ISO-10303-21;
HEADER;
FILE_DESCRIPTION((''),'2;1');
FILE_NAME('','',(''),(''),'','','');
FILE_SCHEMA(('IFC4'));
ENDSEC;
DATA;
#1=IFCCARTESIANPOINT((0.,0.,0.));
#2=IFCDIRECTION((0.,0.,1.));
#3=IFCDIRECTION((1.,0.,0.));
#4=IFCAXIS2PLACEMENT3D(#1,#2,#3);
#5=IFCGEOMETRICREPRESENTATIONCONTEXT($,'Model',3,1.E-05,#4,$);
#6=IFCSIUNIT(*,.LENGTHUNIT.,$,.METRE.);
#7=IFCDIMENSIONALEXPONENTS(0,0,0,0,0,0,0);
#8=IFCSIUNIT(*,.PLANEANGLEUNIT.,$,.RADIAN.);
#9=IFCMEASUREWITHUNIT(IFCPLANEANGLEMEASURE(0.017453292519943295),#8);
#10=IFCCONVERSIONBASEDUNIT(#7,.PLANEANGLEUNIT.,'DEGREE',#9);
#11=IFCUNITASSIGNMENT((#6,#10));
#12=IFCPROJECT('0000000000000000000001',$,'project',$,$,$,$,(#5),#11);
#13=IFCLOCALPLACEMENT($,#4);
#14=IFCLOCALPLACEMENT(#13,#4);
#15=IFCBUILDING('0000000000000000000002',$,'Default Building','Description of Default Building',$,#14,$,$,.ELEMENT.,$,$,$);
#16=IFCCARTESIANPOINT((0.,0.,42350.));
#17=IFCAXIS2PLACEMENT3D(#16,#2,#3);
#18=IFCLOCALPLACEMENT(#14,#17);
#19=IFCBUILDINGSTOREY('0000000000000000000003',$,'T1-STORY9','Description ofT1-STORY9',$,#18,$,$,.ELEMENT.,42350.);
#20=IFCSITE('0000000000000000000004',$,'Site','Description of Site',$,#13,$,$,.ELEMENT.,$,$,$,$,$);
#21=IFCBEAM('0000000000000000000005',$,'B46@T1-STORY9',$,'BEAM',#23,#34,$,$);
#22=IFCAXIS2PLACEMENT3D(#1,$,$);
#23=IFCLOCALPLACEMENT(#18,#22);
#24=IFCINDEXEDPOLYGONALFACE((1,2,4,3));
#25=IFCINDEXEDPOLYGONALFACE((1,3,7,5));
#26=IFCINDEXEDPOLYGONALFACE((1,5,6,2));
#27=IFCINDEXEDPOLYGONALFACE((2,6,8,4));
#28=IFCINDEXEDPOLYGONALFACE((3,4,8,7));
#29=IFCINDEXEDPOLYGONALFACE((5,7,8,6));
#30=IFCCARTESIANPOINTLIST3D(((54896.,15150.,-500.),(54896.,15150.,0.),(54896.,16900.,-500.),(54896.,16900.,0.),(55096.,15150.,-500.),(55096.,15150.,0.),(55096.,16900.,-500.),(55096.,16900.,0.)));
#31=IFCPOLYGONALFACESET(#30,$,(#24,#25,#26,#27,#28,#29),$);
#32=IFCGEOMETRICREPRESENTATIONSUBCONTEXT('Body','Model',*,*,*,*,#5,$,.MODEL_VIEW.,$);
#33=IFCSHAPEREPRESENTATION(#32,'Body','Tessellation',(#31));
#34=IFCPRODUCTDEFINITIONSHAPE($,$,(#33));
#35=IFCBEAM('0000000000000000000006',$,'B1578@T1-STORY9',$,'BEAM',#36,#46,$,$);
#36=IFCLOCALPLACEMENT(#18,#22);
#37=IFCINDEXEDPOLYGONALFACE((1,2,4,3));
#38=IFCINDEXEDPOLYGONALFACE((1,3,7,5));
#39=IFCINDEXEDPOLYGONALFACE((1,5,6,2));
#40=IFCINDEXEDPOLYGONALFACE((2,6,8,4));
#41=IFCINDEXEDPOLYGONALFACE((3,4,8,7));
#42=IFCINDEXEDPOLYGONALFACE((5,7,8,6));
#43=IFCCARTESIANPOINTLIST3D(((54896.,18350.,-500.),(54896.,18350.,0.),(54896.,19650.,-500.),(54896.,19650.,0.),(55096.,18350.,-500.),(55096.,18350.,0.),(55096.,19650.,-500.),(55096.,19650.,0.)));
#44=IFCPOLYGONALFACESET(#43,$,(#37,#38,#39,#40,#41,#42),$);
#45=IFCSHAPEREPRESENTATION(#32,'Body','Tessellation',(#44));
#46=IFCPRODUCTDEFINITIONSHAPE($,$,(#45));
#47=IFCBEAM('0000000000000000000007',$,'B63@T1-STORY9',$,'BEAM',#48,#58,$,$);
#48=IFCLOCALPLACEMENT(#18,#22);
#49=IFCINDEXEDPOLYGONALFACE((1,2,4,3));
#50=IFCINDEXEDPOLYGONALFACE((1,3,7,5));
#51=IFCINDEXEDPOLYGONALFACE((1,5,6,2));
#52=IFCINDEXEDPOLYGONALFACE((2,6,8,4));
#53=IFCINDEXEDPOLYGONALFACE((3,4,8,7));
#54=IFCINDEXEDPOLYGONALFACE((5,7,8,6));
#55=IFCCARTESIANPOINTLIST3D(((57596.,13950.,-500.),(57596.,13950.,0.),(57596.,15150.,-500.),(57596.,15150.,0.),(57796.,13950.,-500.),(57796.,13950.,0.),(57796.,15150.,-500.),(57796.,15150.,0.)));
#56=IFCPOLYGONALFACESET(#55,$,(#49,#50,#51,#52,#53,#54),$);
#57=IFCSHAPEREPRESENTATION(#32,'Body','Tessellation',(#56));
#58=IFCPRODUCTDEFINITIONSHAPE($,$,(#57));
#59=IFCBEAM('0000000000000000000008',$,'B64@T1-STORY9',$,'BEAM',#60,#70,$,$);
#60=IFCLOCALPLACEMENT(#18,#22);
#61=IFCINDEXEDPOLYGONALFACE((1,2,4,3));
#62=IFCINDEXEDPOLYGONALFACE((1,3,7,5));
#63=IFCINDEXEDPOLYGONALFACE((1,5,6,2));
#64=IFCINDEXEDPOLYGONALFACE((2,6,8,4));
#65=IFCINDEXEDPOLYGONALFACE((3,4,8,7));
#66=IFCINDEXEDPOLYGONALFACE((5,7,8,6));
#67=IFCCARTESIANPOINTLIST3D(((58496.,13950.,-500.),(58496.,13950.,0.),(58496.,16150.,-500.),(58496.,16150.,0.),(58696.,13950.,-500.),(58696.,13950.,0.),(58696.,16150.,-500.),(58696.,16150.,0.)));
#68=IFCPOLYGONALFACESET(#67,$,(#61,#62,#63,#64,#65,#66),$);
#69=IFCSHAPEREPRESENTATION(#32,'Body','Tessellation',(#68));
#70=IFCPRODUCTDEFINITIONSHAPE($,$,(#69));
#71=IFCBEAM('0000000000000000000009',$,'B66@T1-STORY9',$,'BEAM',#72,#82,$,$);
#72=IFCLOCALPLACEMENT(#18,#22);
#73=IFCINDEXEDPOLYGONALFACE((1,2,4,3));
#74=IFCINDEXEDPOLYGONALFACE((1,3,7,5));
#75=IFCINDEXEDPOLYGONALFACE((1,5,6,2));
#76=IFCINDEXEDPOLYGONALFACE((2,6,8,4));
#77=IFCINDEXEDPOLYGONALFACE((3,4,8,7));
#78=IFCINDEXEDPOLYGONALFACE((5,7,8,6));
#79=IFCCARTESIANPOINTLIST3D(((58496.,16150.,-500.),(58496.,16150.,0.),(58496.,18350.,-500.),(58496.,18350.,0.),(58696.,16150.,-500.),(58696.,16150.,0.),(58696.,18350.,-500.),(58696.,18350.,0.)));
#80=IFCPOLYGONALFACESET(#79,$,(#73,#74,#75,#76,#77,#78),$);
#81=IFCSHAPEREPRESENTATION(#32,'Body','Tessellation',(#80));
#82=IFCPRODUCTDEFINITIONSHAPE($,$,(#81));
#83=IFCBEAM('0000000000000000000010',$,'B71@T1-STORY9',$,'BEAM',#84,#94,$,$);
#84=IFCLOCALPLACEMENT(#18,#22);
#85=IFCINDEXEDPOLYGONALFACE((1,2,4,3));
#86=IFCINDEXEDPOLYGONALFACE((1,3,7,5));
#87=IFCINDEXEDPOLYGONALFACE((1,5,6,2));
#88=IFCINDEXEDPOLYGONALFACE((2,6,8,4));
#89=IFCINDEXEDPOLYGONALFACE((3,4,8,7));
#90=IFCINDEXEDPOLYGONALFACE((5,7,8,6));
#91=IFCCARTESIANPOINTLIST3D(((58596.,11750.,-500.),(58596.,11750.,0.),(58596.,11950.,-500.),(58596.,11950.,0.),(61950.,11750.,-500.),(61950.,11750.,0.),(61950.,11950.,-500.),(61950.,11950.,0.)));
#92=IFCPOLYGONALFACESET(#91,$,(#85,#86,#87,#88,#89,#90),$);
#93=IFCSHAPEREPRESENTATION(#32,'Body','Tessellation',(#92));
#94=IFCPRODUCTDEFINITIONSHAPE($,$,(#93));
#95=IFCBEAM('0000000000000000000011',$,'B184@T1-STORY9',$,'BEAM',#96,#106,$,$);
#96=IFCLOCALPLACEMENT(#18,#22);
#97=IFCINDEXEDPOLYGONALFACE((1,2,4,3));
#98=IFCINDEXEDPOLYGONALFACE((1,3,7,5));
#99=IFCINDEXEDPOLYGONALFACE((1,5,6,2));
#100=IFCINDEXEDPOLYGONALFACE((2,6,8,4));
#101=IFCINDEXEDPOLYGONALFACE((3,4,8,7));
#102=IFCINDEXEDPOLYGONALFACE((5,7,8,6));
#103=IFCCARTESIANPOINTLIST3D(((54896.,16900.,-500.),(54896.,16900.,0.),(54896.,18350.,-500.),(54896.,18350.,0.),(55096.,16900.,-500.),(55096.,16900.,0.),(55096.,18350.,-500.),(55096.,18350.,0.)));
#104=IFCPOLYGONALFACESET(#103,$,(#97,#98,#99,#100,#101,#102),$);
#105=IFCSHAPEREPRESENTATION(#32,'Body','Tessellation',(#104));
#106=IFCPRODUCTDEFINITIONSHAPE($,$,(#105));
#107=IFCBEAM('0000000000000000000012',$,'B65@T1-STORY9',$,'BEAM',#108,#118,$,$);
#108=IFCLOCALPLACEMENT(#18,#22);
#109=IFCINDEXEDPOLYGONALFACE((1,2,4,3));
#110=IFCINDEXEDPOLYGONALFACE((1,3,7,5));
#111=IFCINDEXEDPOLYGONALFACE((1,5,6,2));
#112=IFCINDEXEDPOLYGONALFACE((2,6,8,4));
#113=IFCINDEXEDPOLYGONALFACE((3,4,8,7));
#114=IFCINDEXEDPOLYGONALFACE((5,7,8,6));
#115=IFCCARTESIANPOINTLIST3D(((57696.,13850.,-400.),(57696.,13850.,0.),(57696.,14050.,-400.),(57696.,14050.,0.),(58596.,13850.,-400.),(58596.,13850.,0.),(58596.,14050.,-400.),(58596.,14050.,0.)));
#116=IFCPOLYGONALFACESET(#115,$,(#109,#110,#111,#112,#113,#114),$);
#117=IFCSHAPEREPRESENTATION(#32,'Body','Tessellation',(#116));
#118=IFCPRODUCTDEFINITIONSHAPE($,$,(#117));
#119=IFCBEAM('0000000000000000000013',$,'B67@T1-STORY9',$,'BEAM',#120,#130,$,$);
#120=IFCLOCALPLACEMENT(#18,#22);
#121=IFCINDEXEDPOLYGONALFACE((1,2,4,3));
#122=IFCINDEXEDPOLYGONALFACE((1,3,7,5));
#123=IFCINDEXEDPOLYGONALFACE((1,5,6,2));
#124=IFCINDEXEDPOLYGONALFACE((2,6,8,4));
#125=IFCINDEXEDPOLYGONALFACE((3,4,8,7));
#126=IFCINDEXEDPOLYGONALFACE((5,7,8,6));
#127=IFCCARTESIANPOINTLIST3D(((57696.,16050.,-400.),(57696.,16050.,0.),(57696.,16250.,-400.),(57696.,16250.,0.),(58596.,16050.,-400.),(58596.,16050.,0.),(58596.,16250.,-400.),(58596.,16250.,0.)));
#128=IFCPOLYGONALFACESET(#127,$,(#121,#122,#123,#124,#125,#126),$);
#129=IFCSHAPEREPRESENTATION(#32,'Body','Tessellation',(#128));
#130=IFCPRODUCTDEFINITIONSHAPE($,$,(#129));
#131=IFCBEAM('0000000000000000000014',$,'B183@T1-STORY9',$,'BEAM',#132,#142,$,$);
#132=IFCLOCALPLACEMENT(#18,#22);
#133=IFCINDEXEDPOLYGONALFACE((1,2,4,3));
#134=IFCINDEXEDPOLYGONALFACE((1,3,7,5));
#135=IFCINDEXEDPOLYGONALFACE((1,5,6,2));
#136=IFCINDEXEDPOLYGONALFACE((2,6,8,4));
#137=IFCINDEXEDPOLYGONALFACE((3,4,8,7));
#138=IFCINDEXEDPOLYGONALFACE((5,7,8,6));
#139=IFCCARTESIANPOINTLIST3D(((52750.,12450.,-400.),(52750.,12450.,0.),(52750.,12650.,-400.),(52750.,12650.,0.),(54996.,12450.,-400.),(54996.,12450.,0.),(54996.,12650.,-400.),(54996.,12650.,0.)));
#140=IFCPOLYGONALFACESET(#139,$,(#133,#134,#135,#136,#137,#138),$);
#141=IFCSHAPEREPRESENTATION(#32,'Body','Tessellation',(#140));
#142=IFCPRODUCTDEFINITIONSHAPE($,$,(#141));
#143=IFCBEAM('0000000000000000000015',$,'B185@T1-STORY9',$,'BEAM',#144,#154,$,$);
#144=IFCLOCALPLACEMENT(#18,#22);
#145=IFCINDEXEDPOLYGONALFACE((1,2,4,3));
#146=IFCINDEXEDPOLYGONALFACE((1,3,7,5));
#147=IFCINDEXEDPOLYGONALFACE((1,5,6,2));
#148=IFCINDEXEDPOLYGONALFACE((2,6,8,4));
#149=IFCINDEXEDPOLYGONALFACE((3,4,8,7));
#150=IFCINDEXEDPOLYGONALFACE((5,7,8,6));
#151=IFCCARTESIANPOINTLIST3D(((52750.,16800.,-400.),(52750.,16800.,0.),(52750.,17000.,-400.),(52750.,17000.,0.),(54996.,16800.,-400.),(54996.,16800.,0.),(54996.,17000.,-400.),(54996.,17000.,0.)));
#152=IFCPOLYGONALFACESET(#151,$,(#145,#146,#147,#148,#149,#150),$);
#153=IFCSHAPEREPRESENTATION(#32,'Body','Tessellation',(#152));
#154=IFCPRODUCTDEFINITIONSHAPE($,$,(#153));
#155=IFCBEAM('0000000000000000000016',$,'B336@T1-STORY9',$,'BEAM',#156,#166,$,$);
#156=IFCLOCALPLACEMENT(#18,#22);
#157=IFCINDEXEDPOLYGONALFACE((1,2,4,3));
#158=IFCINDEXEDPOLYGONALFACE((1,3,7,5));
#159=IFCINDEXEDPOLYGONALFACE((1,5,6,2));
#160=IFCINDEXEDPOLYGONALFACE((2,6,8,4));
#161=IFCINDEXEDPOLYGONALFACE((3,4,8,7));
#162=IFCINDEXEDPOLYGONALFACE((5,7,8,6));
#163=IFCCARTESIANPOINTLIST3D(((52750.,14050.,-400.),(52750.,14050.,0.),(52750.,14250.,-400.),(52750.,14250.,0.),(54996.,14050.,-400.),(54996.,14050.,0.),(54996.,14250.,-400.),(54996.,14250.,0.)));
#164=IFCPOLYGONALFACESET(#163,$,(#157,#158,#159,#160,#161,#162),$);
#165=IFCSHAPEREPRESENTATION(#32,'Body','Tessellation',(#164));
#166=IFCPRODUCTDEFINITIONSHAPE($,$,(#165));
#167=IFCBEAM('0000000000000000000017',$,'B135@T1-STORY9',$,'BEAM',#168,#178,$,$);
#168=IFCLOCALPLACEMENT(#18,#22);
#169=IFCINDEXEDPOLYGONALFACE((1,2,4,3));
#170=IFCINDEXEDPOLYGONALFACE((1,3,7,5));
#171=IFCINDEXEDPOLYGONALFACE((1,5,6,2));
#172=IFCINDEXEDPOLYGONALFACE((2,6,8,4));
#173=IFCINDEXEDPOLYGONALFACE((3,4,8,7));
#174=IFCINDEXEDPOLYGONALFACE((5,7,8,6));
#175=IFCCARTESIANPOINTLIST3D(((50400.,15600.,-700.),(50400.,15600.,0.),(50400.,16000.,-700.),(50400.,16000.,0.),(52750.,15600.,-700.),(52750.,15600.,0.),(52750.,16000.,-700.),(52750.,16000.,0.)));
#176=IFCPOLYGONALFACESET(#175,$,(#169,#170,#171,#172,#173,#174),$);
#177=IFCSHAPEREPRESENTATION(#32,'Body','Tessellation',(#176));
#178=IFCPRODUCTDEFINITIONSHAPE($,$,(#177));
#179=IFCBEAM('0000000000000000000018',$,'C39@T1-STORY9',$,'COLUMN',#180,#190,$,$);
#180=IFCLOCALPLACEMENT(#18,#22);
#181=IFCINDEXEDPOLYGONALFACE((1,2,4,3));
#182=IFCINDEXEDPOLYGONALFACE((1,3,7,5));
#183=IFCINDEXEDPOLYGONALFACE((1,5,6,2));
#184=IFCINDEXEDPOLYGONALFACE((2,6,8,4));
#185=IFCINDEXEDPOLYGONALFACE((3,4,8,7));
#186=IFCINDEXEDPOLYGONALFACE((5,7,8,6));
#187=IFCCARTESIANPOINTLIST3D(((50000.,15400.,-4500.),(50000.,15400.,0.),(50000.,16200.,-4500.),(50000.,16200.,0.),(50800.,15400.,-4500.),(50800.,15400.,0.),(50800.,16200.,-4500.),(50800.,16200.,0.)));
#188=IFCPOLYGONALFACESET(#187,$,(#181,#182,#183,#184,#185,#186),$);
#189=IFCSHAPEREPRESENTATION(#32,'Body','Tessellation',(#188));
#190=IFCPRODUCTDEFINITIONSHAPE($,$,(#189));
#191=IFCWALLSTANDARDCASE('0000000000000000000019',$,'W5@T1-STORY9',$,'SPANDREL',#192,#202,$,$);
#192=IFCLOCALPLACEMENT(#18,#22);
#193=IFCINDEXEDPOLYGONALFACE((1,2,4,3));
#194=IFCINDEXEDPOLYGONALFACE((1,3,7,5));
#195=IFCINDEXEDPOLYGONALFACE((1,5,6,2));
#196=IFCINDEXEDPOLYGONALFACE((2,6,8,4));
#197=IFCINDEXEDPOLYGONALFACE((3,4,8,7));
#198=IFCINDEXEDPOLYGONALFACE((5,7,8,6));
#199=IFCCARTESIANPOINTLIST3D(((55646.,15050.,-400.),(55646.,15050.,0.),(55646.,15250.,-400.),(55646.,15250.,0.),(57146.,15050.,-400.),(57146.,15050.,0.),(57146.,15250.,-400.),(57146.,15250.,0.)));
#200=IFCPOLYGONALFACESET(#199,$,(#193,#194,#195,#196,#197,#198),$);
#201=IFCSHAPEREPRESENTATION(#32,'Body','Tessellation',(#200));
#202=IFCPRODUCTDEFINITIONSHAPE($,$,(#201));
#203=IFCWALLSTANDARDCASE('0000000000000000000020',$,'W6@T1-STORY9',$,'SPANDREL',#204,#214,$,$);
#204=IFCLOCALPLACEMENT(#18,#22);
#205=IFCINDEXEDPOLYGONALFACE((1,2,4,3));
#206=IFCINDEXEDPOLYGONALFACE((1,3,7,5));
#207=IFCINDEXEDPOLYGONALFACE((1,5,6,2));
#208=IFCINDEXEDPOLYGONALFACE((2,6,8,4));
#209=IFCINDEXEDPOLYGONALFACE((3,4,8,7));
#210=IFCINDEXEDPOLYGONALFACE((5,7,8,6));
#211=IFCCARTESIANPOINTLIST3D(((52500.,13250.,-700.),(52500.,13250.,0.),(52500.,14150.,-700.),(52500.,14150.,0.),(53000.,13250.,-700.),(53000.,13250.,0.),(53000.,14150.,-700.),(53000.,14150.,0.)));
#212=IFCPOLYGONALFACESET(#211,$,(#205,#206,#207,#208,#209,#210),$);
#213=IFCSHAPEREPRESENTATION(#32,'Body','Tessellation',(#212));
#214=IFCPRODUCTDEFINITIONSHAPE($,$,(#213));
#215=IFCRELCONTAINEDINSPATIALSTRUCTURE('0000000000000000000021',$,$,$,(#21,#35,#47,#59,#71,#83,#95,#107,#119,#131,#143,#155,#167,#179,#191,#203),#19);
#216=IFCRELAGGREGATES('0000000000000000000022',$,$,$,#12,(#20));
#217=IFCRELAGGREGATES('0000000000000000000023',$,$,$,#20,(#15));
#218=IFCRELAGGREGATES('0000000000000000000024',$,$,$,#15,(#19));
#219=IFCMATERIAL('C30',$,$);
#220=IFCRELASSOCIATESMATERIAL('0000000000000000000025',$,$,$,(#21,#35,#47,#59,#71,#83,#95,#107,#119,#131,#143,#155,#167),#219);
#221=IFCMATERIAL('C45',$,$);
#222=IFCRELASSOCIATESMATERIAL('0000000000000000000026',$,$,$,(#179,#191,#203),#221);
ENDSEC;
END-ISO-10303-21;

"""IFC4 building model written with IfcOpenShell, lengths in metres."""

from ifc_helpers import new_model, entity, si_unit, converted_unit, frame, origin_with_axes, place, context, subcontext, project, spatial, indexed_curve, rectangle, outline, extrude, material, element, save


model = new_model("IFC4")

# Units and contexts
model_context = context("Model", 3, precision=1e-05, world=origin_with_axes())
body_context = subcontext(model_context, "Body", "Model", "MODEL_VIEW")
ifc_project = project(units=[si_unit("LENGTHUNIT", "METRE"), converted_unit("PLANEANGLEUNIT", "DEGREE", entity("IfcPlaneAngleMeasure", 0.017453292519943295), si_unit("PLANEANGLEUNIT", "RADIAN"), dimensions=[0, 0, 0, 0, 0, 0, 0])], contexts=[model_context])

# Site, building, storey
site_placement = place(None, origin_with_axes())
site = spatial("IfcSite", under=ifc_project, at=site_placement, Name="Site", Description="Description of Site", CompositionType="ELEMENT")
building_placement = place(site_placement, origin_with_axes())
building = spatial("IfcBuilding", under=site, at=building_placement, Name="Default Building", Description="Description of Default Building", CompositionType="ELEMENT")
storey_placement = place(building_placement, frame((0.0, 0.0, 42350.0), z_axis=(0.0, 0.0, 1.0), x_axis=(1.0, 0.0, 0.0)))
storey = spatial("IfcBuildingStorey", under=building, at=storey_placement, Name="T1-STORY9", Description="Description ofT1-STORY9", CompositionType="ELEMENT", Elevation=42350.0)

# Beams
ifc_material_1 = material(Name="C30")
beam_1_placement = place(storey_placement, frame((54996.0, 15150.0, -250.0), z_axis=(0.0, 1.0, 0.0), x_axis=(-1.0, 0.0, 0.0)))
element("IfcBeam", 1, at=beam_1_placement, inside=storey, material=ifc_material_1, Name="B46@T1-STORY9", ObjectType="BEAM", context=body_context, shape_type="SweptSolid", body=[
    extrude(rectangle(XDim=200.0, YDim=500.0), origin_with_axes(), (0.0, 0.0, 1.0), 1750.0),
])
beam_2_placement = place(storey_placement, frame((54996.0, 18350.0, -250.0), z_axis=(0.0, 1.0, 0.0), x_axis=(-1.0, 0.0, 0.0)))
element("IfcBeam", 2, at=beam_2_placement, inside=storey, material=ifc_material_1, Name="B1578@T1-STORY9", ObjectType="BEAM", context=body_context, shape_type="SweptSolid", body=[
    extrude(rectangle(XDim=200.0, YDim=500.0), origin_with_axes(), (0.0, 0.0, 1.0), 1300.0),
])
beam_3_placement = place(storey_placement, frame((57696.0, 13950.0, -250.0), z_axis=(0.0, 1.0, 0.0), x_axis=(-1.0, 0.0, 0.0)))
element("IfcBeam", 3, at=beam_3_placement, inside=storey, material=ifc_material_1, Name="B63@T1-STORY9", ObjectType="BEAM", context=body_context, shape_type="SweptSolid", body=[
    extrude(rectangle(XDim=200.0, YDim=500.0), origin_with_axes(), (0.0, 0.0, 1.0), 1200.0),
])
for number, where, z_axis, x_axis, name in (
    (4, (58596.0, 13950.0, -250.0), (0.0, 1.0, 0.0), (-1.0, 0.0, 0.0), "B64@T1-STORY9"),
    (5, (58596.0, 16150.0, -250.0), (0.0, 1.0, 0.0), (-1.0, 0.0, 0.0), "B66@T1-STORY9"),
):
    element("IfcBeam", number, at=place(storey_placement, frame(where, z_axis=z_axis, x_axis=x_axis)), inside=storey, material=ifc_material_1, Name=name, ObjectType="BEAM", context=body_context, shape_type="SweptSolid", body=[
        extrude(rectangle(XDim=200.0, YDim=500.0), origin_with_axes(), (0.0, 0.0, 1.0), 2200.0),
    ])
beam_4_placement = place(storey_placement, frame((58596.0, 11850.0, -250.0), z_axis=(1.0, 0.0, 0.0), x_axis=(0.0, 1.0, 0.0)))
element("IfcBeam", 6, at=beam_4_placement, inside=storey, material=ifc_material_1, Name="B71@T1-STORY9", ObjectType="BEAM", context=body_context, shape_type="SweptSolid", body=[
    extrude(rectangle(XDim=200.0, YDim=500.0), origin_with_axes(), (0.0, 0.0, 1.0), 3354.0),
])
beam_5_placement = place(storey_placement, frame((54996.0, 16900.0, -250.0), z_axis=(0.0, 1.0, 0.0), x_axis=(-1.0, 0.0, 0.0)))
element("IfcBeam", 7, at=beam_5_placement, inside=storey, material=ifc_material_1, Name="B184@T1-STORY9", ObjectType="BEAM", context=body_context, shape_type="SweptSolid", body=[
    extrude(rectangle(XDim=200.0, YDim=500.0), origin_with_axes(), (0.0, 0.0, 1.0), 1450.0),
])
for number, where, z_axis, x_axis, name in (
    (8, (57696.0, 13950.0, -200.0), (1.0, 0.0, 0.0), (0.0, 1.0, 0.0), "B65@T1-STORY9"),
    (9, (57696.0, 16150.0, -200.0), (1.0, 0.0, 0.0), (0.0, 1.0, 0.0), "B67@T1-STORY9"),
):
    element("IfcBeam", number, at=place(storey_placement, frame(where, z_axis=z_axis, x_axis=x_axis)), inside=storey, material=ifc_material_1, Name=name, ObjectType="BEAM", context=body_context, shape_type="SweptSolid", body=[
        extrude(rectangle(XDim=200.0, YDim=400.0), origin_with_axes(), (0.0, 0.0, 1.0), 900.0),
    ])
for number, where, z_axis, x_axis, name in (
    (10, (52750.0, 12550.0, -200.0), (1.0, 0.0, 0.0), (0.0, 1.0, 0.0), "B183@T1-STORY9"),
    (11, (52750.0, 16900.0, -200.0), (1.0, 0.0, 0.0), (0.0, 1.0, 0.0), "B185@T1-STORY9"),
    (12, (52750.0, 14150.0, -200.0), (1.0, 0.0, 0.0), (0.0, 1.0, 0.0), "B336@T1-STORY9"),
):
    element("IfcBeam", number, at=place(storey_placement, frame(where, z_axis=z_axis, x_axis=x_axis)), inside=storey, material=ifc_material_1, Name=name, ObjectType="BEAM", context=body_context, shape_type="SweptSolid", body=[
        extrude(rectangle(XDim=200.0, YDim=400.0), origin_with_axes(), (0.0, 0.0, 1.0), 2246.0),
    ])
beam_6_placement = place(storey_placement, frame((50400.0, 15800.0, -350.0), z_axis=(1.0, 0.0, 0.0), x_axis=(0.0, 1.0, 0.0)))
element("IfcBeam", 13, at=beam_6_placement, inside=storey, material=ifc_material_1, Name="B135@T1-STORY9", ObjectType="BEAM", context=body_context, shape_type="SweptSolid", body=[
    extrude(rectangle(XDim=400.0, YDim=700.0), origin_with_axes(), (0.0, 0.0, 1.0), 2350.0),
])
ifc_material_2 = material(Name="C45")
beam_7_placement = place(storey_placement, frame((50400.0, 15800.0, -4500.0), z_axis=(0.0, 0.0, 1.0), x_axis=(-1.0, 0.0, 0.0)))
element("IfcBeam", 14, at=beam_7_placement, inside=storey, material=ifc_material_2, Name="C39@T1-STORY9", ObjectType="COLUMN", context=body_context, shape_type="SweptSolid", body=[
    extrude(rectangle(XDim=800.0, YDim=800.0), origin_with_axes(), (0.0, 0.0, 1.0), 4500.0),
])

# Walls
wall_1_placement = place(storey_placement, frame((55646.0, 15150.0, -400.0), z_axis=(0.0, 0.0, 1.0), x_axis=(1.0, 0.0, 0.0)))
element("IfcWallStandardCase", 15, at=wall_1_placement, inside=storey, material=ifc_material_2, Name="W5@T1-STORY9", ObjectType="SPANDREL", context=body_context, shape_type="SweptSolid", body=[
    extrude(outline(indexed_curve([(0.0, -100.0), (0.0, 100.0), (1500.0, 100.0), (1500.0, -100.0), (0.0, -100.0)], self_intersect=False)), origin_with_axes(), (0.0, 0.0, 1.0), 400.0),
])
wall_2_placement = place(storey_placement, frame((52750.0, 13250.0, -700.0), z_axis=(0.0, 0.0, 1.0), x_axis=(0.0, 1.0, 0.0)))
element("IfcWallStandardCase", 16, at=wall_2_placement, inside=storey, material=ifc_material_2, Name="W6@T1-STORY9", ObjectType="SPANDREL", context=body_context, shape_type="SweptSolid", body=[
    extrude(outline(indexed_curve([(0.0, -250.0), (0.0, 250.0), (900.0, 250.0), (900.0, -250.0), (0.0, -250.0)], self_intersect=False)), origin_with_axes(), (0.0, 0.0, 1.0), 700.0),
])

save(model, "model.ifc")
